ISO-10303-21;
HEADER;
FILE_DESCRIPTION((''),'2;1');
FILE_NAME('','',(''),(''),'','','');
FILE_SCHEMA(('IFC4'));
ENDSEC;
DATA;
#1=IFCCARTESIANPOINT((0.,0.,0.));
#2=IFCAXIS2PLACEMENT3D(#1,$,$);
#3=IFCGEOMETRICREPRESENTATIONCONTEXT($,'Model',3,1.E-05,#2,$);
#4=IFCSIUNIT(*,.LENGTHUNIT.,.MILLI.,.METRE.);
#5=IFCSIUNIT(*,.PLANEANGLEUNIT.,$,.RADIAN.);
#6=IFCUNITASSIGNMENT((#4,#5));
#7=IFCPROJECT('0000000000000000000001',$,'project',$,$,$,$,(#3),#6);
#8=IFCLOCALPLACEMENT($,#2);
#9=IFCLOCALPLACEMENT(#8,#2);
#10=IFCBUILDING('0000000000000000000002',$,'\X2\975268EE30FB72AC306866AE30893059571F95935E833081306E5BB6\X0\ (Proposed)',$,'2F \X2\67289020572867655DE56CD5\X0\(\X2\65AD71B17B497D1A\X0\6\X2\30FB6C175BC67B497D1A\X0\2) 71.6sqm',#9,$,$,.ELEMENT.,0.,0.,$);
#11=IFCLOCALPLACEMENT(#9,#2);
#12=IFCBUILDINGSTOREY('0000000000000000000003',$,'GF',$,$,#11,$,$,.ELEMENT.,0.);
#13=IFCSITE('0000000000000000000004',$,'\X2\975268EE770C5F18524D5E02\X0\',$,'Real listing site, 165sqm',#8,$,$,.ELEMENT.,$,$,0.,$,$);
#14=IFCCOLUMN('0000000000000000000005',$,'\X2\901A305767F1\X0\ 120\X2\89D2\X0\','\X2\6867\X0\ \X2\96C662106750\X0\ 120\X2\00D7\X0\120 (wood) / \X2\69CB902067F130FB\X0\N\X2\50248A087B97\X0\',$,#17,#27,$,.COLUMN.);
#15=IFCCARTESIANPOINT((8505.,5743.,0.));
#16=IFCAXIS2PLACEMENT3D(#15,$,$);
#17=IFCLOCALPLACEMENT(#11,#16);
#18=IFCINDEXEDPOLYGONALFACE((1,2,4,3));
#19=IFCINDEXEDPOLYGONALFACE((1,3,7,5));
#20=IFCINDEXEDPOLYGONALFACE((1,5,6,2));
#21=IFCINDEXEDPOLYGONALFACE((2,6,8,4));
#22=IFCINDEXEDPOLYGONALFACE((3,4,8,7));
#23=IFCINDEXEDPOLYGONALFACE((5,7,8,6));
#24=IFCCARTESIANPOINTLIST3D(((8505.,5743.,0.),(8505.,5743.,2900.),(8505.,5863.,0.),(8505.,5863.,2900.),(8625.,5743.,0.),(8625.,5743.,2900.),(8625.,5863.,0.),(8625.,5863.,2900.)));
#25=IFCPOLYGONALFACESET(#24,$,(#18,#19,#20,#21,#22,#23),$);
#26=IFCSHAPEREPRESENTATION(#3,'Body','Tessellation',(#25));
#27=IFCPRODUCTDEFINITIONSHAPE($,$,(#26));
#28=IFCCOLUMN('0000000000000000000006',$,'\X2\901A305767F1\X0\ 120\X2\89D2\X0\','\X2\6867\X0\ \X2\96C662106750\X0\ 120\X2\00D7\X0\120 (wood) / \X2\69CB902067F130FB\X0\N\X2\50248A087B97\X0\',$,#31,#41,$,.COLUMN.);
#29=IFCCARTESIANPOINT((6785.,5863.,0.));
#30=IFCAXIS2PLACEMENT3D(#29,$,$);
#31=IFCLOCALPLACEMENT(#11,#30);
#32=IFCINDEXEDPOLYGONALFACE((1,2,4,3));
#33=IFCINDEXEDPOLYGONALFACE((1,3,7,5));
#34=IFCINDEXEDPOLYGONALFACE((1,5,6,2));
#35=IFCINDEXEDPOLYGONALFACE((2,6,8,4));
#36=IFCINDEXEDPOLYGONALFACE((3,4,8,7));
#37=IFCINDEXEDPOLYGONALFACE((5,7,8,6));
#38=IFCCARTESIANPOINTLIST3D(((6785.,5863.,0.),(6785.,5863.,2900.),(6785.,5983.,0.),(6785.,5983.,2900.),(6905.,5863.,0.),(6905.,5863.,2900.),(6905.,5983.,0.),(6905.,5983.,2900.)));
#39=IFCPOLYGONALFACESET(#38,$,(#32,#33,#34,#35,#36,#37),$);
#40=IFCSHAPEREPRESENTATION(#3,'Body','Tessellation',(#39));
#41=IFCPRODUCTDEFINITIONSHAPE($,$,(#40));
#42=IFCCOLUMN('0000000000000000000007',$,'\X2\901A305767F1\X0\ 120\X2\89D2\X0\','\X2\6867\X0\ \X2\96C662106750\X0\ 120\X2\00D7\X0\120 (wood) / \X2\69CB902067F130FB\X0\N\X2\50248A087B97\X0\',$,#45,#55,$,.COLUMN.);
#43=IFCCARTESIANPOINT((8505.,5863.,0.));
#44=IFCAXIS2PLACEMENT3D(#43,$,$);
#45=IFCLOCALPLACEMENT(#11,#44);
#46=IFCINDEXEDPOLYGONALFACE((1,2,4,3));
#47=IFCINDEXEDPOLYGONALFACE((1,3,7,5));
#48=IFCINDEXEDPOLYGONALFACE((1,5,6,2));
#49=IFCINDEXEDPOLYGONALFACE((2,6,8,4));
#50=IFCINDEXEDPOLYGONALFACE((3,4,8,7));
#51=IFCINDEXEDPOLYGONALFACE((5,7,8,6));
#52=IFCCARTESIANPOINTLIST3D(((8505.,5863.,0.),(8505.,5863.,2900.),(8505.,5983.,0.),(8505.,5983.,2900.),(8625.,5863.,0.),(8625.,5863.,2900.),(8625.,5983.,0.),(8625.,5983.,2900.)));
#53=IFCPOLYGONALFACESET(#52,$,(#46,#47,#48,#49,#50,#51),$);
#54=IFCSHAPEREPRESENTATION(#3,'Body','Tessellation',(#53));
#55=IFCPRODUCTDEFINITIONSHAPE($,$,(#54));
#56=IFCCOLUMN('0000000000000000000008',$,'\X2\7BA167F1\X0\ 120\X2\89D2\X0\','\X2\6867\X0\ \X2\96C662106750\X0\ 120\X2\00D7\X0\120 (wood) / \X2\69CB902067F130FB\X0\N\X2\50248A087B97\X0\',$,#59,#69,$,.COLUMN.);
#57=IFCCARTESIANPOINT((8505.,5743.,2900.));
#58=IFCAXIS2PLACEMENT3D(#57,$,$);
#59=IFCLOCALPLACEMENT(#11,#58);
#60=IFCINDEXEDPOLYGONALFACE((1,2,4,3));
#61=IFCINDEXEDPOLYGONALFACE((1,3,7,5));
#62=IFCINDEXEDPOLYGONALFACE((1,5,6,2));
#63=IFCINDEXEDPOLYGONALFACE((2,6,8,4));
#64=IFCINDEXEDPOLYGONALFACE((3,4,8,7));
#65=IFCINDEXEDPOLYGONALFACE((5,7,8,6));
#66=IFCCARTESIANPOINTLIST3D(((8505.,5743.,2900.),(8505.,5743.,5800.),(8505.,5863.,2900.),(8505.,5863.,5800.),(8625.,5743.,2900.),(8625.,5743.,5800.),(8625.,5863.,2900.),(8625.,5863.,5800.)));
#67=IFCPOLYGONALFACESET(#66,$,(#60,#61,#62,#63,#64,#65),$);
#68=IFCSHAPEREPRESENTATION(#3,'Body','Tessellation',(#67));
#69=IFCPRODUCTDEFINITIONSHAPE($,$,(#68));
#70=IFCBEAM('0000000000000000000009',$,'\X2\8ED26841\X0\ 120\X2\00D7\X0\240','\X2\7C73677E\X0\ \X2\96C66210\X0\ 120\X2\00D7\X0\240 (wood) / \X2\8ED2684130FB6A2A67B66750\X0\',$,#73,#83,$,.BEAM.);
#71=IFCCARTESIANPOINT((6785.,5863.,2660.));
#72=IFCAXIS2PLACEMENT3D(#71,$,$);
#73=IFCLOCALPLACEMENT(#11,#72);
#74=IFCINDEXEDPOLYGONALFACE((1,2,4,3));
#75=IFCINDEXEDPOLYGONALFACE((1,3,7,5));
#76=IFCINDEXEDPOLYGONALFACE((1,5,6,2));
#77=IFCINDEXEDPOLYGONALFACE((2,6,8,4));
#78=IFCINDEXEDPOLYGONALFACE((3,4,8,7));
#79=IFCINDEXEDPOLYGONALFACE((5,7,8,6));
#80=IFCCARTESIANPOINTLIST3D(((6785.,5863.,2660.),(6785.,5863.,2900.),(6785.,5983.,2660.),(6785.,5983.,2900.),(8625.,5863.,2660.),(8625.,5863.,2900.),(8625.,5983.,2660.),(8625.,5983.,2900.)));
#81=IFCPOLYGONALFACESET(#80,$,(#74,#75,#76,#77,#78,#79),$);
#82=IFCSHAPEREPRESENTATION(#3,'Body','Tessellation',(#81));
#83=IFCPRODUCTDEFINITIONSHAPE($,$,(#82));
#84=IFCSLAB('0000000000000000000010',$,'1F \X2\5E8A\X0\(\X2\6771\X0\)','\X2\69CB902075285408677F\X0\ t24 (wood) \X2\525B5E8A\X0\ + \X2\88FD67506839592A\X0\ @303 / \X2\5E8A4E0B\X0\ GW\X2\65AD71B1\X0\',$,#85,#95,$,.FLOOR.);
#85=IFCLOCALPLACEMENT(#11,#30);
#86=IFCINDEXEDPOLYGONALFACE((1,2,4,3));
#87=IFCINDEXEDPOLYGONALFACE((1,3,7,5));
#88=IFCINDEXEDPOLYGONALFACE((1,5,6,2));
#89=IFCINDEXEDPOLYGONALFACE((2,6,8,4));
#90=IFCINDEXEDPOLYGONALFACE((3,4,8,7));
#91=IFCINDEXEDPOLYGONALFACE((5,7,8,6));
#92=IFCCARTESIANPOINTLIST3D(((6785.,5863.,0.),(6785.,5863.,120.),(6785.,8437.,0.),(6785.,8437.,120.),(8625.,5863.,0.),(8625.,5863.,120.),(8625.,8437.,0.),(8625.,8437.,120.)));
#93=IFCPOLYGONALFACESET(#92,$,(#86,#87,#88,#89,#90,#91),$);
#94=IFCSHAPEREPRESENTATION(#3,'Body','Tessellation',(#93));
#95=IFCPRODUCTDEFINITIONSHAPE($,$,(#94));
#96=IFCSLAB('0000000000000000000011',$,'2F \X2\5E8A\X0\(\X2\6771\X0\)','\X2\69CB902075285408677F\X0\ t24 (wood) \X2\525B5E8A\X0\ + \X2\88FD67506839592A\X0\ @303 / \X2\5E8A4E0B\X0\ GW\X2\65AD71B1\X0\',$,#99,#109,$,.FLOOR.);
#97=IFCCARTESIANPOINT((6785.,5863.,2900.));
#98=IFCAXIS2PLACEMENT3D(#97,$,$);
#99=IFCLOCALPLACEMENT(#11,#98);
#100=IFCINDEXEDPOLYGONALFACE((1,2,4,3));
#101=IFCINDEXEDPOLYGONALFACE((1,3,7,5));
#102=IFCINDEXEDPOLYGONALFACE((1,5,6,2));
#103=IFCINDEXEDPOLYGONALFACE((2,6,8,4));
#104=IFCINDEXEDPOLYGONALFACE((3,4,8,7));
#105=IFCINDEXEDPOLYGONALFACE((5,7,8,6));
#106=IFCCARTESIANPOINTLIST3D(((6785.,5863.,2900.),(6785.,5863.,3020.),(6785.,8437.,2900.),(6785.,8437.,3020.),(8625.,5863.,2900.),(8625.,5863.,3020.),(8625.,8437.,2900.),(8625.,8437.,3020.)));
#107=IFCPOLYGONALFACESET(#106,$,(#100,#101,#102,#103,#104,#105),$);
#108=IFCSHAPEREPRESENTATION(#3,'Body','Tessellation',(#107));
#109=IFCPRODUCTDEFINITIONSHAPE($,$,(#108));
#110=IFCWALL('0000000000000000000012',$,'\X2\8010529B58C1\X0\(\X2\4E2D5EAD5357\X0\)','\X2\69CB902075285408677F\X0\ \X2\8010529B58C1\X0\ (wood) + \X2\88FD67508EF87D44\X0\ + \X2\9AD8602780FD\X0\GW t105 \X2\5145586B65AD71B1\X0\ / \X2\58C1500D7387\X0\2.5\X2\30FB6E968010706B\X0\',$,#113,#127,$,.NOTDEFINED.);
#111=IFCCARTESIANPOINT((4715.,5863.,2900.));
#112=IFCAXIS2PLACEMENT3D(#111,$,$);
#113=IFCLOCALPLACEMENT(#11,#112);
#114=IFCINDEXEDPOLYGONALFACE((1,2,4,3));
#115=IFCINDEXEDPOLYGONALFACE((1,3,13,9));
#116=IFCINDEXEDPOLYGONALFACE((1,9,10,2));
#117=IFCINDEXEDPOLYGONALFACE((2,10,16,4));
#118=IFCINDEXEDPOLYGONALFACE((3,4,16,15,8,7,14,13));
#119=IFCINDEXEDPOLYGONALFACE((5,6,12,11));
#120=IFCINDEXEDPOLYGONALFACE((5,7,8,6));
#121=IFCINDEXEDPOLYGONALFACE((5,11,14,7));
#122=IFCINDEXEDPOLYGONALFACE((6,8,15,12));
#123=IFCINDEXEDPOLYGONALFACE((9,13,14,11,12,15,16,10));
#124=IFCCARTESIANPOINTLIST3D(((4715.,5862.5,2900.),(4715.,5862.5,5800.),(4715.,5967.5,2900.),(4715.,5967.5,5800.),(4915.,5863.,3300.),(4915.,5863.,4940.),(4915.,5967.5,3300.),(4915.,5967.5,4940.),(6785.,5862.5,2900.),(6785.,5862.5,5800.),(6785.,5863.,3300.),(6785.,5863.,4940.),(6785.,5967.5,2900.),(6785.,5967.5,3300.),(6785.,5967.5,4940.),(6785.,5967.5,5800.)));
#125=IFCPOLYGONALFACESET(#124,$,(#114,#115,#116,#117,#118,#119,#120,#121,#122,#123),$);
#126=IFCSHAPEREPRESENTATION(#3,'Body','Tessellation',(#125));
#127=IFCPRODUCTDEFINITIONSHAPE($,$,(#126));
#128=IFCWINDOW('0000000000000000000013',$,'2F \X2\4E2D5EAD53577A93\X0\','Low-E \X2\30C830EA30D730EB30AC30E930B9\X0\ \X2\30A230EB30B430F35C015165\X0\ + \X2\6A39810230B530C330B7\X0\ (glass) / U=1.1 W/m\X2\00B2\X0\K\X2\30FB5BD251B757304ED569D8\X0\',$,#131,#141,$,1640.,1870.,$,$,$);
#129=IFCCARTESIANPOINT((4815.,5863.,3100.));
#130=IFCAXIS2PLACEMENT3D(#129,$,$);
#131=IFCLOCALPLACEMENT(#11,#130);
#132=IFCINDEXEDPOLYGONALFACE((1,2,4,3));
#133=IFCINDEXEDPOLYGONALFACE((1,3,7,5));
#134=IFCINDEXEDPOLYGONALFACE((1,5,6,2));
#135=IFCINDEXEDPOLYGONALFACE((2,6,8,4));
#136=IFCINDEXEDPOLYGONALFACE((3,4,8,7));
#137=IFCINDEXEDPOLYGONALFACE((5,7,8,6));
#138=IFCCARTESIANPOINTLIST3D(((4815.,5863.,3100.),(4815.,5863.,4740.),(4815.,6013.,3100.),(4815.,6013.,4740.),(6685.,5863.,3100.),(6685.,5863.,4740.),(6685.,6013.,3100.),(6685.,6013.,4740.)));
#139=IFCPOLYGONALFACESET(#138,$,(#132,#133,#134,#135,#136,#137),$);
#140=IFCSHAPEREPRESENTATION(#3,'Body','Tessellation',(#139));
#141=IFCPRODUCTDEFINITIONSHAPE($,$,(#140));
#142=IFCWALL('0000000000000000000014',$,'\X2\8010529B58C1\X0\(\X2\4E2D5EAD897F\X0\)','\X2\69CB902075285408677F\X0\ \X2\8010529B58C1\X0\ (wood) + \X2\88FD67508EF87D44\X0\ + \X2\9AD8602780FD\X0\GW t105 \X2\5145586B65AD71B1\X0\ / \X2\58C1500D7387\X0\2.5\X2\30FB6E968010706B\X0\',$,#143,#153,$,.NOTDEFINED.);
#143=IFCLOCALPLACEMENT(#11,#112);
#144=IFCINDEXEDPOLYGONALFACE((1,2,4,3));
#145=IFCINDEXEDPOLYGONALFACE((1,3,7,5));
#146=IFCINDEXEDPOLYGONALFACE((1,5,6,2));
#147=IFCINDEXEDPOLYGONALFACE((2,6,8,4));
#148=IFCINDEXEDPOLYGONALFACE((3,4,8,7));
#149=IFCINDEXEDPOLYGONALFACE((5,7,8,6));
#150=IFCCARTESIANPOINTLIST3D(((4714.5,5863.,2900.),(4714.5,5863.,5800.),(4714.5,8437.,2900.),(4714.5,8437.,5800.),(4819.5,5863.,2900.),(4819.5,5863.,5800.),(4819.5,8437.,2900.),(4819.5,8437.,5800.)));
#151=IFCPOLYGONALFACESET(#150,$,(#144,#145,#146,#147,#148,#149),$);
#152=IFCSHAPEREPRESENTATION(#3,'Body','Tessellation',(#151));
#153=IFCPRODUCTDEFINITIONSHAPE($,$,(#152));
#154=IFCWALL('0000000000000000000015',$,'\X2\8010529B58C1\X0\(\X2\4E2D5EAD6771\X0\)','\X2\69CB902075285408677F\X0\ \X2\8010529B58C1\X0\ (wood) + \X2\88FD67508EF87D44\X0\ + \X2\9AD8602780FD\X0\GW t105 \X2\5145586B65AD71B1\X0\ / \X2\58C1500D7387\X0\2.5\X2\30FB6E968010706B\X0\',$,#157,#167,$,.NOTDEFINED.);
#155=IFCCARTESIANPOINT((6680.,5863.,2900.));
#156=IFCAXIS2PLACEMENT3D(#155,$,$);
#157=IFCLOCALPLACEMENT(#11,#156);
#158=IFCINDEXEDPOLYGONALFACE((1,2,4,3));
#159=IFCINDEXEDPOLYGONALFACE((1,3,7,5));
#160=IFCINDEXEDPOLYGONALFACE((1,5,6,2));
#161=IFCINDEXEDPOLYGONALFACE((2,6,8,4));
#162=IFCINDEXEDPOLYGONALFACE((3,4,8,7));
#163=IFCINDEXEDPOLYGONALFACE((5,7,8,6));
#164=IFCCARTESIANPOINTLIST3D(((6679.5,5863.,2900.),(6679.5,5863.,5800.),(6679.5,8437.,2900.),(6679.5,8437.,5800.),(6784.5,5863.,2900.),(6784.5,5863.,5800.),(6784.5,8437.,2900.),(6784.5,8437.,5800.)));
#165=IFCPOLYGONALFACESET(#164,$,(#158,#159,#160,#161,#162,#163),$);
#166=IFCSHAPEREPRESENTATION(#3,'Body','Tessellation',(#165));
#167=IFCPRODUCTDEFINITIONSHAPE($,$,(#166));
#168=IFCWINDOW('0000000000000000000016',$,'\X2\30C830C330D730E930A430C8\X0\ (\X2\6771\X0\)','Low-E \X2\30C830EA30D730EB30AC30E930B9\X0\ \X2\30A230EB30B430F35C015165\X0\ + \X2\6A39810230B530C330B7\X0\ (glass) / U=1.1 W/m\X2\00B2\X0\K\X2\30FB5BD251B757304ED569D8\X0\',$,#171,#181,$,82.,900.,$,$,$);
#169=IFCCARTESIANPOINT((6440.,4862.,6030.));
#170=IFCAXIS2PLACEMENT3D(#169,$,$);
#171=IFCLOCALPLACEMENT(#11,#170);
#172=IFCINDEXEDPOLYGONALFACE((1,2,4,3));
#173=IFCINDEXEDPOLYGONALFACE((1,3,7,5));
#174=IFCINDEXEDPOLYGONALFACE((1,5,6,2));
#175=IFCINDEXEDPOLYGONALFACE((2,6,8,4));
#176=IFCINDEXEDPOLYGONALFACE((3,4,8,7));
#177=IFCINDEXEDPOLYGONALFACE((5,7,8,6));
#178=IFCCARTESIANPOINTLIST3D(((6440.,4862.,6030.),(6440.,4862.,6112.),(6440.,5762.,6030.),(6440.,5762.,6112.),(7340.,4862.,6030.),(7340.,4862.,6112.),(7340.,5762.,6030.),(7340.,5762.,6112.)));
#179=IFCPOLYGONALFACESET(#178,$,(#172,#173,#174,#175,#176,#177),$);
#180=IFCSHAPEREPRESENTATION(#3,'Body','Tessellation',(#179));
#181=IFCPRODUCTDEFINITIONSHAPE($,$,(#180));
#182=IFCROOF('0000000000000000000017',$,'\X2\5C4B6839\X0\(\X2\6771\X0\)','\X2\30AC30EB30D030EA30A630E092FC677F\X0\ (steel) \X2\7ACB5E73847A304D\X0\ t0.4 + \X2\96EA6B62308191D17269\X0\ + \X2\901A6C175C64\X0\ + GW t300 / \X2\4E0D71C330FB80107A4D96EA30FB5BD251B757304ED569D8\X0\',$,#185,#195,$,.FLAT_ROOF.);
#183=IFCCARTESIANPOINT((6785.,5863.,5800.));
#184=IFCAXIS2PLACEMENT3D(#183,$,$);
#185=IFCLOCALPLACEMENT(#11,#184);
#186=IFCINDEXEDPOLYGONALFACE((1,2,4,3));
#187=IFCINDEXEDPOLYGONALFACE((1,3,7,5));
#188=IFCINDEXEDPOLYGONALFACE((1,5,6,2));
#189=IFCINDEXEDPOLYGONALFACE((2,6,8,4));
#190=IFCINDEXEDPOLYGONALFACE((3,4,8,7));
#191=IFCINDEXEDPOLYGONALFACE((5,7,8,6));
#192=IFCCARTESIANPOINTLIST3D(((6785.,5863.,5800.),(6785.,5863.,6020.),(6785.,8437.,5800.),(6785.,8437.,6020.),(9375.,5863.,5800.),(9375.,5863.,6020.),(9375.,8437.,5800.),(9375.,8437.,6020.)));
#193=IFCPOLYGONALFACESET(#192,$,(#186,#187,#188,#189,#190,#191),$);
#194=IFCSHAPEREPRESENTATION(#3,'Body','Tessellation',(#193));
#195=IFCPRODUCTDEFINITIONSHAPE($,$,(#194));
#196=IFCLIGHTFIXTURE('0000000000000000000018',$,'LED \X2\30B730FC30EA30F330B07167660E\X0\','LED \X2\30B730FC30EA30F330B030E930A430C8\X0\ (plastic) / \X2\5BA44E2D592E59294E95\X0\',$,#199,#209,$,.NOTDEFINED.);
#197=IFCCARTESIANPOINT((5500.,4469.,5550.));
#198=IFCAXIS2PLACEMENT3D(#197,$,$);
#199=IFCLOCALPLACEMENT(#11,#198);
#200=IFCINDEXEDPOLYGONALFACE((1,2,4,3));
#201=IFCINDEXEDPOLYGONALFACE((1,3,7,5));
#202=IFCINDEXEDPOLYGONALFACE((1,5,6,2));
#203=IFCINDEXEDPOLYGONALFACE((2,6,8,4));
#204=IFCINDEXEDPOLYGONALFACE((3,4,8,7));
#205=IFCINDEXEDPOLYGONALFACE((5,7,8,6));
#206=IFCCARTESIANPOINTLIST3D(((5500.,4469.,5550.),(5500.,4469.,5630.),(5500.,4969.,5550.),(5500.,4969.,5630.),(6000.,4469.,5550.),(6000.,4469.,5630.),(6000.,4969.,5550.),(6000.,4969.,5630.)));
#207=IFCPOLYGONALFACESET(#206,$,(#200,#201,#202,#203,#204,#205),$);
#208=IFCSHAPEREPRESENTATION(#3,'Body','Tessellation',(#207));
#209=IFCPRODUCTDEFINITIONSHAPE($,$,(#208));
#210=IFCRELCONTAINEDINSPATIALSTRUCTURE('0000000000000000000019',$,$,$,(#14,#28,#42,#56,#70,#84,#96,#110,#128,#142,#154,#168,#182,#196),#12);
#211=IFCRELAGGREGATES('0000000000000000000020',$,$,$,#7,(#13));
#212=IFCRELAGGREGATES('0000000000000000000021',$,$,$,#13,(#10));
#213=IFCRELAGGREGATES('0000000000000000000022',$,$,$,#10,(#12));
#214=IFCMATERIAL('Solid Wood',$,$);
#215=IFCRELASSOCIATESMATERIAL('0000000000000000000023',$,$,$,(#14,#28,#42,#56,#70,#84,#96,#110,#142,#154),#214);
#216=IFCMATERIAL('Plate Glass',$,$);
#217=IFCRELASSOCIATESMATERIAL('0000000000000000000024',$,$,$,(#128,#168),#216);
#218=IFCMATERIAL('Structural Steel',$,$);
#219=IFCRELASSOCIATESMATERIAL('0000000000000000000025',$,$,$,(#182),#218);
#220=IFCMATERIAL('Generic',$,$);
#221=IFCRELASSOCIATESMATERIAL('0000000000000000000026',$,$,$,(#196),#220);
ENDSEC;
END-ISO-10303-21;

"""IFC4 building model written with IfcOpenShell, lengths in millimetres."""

from ifc_helpers import new_model, si_unit, frame, frame_2d, origin, place, context, project, spatial, rectangle, extrude, material, element, fill, save


model = new_model("IFC4")

# Units and contexts
model_context = context("Model", 3, precision=1e-05, world=origin())
ifc_project = project(units=[si_unit("LENGTHUNIT", "METRE", prefix="MILLI"), si_unit("PLANEANGLEUNIT", "RADIAN")], contexts=[model_context])

# Site, building, storey
site_placement = place(None, origin())
site = spatial("IfcSite", under=ifc_project, at=site_placement, Name="青森県弘前市", ObjectType="Real listing site, 165sqm", CompositionType="ELEMENT", RefElevation=0.0)
building_placement = place(site_placement, origin())
building = spatial("IfcBuilding", under=site, at=building_placement, Name="青森・犬と暮らす土間広めの家 (Proposed)", ObjectType="2F 木造在来工法(断熱等級6・気密等級2) 71.6sqm", CompositionType="ELEMENT", ElevationOfRefHeight=0.0, ElevationOfTerrain=0.0)
storey_placement = place(building_placement, origin())
storey = spatial("IfcBuildingStorey", under=building, at=storey_placement, Name="GF", CompositionType="ELEMENT", Elevation=0.0)

# Columns
ifc_material_1 = material(Name="Solid Wood")
column_1_placement = place(storey_placement, frame((8505.0, 5743.0, 0.0)))
element("IfcColumn", 1, at=column_1_placement, inside=storey, material=ifc_material_1, Name="通し柱 120角", Description="桧 集成材 120×120 (wood) / 構造柱・N値計算", PredefinedType="COLUMN", context=model_context, shape_type="SweptSolid", body=[
    extrude(rectangle(XDim=120.0, YDim=120.0, at=frame_2d((60.0, 60.0))), frame((8505.0, 5743.0, 0.0)), (0.0, 0.0, 1.0), 2900.0),
])
column_2_placement = place(storey_placement, frame((6785.0, 5863.0, 0.0)))
element("IfcColumn", 2, at=column_2_placement, inside=storey, material=ifc_material_1, Name="通し柱 120角", Description="桧 集成材 120×120 (wood) / 構造柱・N値計算", PredefinedType="COLUMN", context=model_context, shape_type="SweptSolid", body=[
    extrude(rectangle(XDim=120.0, YDim=120.0, at=frame_2d((60.0, 60.0))), frame((6785.0, 5863.0, 0.0)), (0.0, 0.0, 1.0), 2900.0),
])
column_3_placement = place(storey_placement, frame((8505.0, 5863.0, 0.0)))
element("IfcColumn", 3, at=column_3_placement, inside=storey, material=ifc_material_1, Name="通し柱 120角", Description="桧 集成材 120×120 (wood) / 構造柱・N値計算", PredefinedType="COLUMN", context=model_context, shape_type="SweptSolid", body=[
    extrude(rectangle(XDim=120.0, YDim=120.0, at=frame_2d((60.0, 60.0))), frame((8505.0, 5863.0, 0.0)), (0.0, 0.0, 1.0), 2900.0),
])
column_4_placement = place(storey_placement, frame((8505.0, 5743.0, 2900.0)))
element("IfcColumn", 4, at=column_4_placement, inside=storey, material=ifc_material_1, Name="管柱 120角", Description="桧 集成材 120×120 (wood) / 構造柱・N値計算", PredefinedType="COLUMN", context=model_context, shape_type="SweptSolid", body=[
    extrude(rectangle(XDim=120.0, YDim=120.0, at=frame_2d((60.0, 60.0))), frame((8505.0, 5743.0, 2900.0)), (0.0, 0.0, 1.0), 2900.0),
])

# Beam
beam_1_placement = place(storey_placement, frame((6785.0, 5863.0, 2660.0)))
element("IfcBeam", 5, at=beam_1_placement, inside=storey, material=ifc_material_1, Name="軒桁 120×240", Description="米松 集成 120×240 (wood) / 軒桁・横架材", PredefinedType="BEAM", context=model_context, shape_type="SweptSolid", body=[
    extrude(rectangle(XDim=1840.0, YDim=120.0, at=frame_2d((920.0, 60.0))), frame((6785.0, 5863.0, 2660.0)), (0.0, 0.0, 1.0), 240.0),
])

# Slabs
slab_1_placement = place(storey_placement, frame((6785.0, 5863.0, 0.0)))
element("IfcSlab", 6, at=slab_1_placement, inside=storey, material=ifc_material_1, Name="1F 床(東)", Description="構造用合板 t24 (wood) 剛床 + 製材根太 @303 / 床下 GW断熱", PredefinedType="FLOOR", context=model_context, shape_type="SweptSolid", body=[
    extrude(rectangle(XDim=1840.0, YDim=2574.0, at=frame_2d((920.0, 1287.0))), frame((6785.0, 5863.0, 0.0)), (0.0, 0.0, 1.0), 120.0),
])
slab_2_placement = place(storey_placement, frame((6785.0, 5863.0, 2900.0)))
element("IfcSlab", 7, at=slab_2_placement, inside=storey, material=ifc_material_1, Name="2F 床(東)", Description="構造用合板 t24 (wood) 剛床 + 製材根太 @303 / 床下 GW断熱", PredefinedType="FLOOR", context=model_context, shape_type="SweptSolid", body=[
    extrude(rectangle(XDim=1840.0, YDim=2574.0, at=frame_2d((920.0, 1287.0))), frame((6785.0, 5863.0, 2900.0)), (0.0, 0.0, 1.0), 120.0),
])

# Wall, opening, window
wall_1_placement = place(storey_placement, frame((4715.0, 5863.0, 2900.0)))
wall_1 = element("IfcWall", 8, at=wall_1_placement, inside=storey, material=ifc_material_1, Name="耐力壁(中庭南)", Description="構造用合板 耐力壁 (wood) + 製材軸組 + 高性能GW t105 充填断熱 / 壁倍率2.5・準耐火", PredefinedType="NOTDEFINED", context=model_context, shape_type="SweptSolid", body=[
    extrude(rectangle(XDim=2070.0, YDim=105.0, at=frame_2d((1035.0, 52.0))), frame((4715.0, 5863.0, 2900.0)), (0.0, 0.0, 1.0), 2900.0),
])
opening_placement = place(storey_placement, frame((4815.0, 5863.0, 3100.0)))
opening = element("IfcOpeningElement", 9, at=opening_placement, cuts=wall_1, PredefinedType="NOTDEFINED", context=model_context, shape_type="SweptSolid", body=[
    extrude(rectangle(XDim=1870.0, YDim=150.0, at=frame_2d((935.0, 75.0))), frame((4815.0, 5863.0, 3100.0)), (0.0, 0.0, 1.0), 1640.0),
])
ifc_material_2 = material(Name="Plate Glass")
window_1_placement = place(storey_placement, frame((4815.0, 5863.0, 3100.0)))
window_1 = element("IfcWindow", 10, at=window_1_placement, inside=storey, material=ifc_material_2, Name="2F 中庭南窓", Description="Low-E トリプルガラス アルゴン封入 + 樹脂サッシ (glass) / U=1.1 W/m²K・寒冷地仕様", OverallHeight=1640.0, OverallWidth=1870.0, context=model_context, shape_type="SweptSolid", body=[
    extrude(rectangle(XDim=1870.0, YDim=150.0, at=frame_2d((935.0, 75.0))), frame((4815.0, 5863.0, 3100.0)), (0.0, 0.0, 1.0), 1640.0),
])
fill(opening, window_1)

# Walls
wall_2_placement = place(storey_placement, frame((4715.0, 5863.0, 2900.0)))
element("IfcWall", 11, at=wall_2_placement, inside=storey, material=ifc_material_1, Name="耐力壁(中庭西)", Description="構造用合板 耐力壁 (wood) + 製材軸組 + 高性能GW t105 充填断熱 / 壁倍率2.5・準耐火", PredefinedType="NOTDEFINED", context=model_context, shape_type="SweptSolid", body=[
    extrude(rectangle(XDim=105.0, YDim=2574.0, at=frame_2d((52.0, 1287.0))), frame((4715.0, 5863.0, 2900.0)), (0.0, 0.0, 1.0), 2900.0),
])
wall_3_placement = place(storey_placement, frame((6680.0, 5863.0, 2900.0)))
element("IfcWall", 12, at=wall_3_placement, inside=storey, material=ifc_material_1, Name="耐力壁(中庭東)", Description="構造用合板 耐力壁 (wood) + 製材軸組 + 高性能GW t105 充填断熱 / 壁倍率2.5・準耐火", PredefinedType="NOTDEFINED", context=model_context, shape_type="SweptSolid", body=[
    extrude(rectangle(XDim=105.0, YDim=2574.0, at=frame_2d((52.0, 1287.0))), frame((6680.0, 5863.0, 2900.0)), (0.0, 0.0, 1.0), 2900.0),
])

# Window
window_2_placement = place(storey_placement, frame((6440.0, 4862.0, 6030.0)))
element("IfcWindow", 13, at=window_2_placement, inside=storey, material=ifc_material_2, Name="トップライト (東)", Description="Low-E トリプルガラス アルゴン封入 + 樹脂サッシ (glass) / U=1.1 W/m²K・寒冷地仕様", OverallHeight=82.0, OverallWidth=900.0, context=model_context, shape_type="SweptSolid", body=[
    extrude(rectangle(XDim=900.0, YDim=900.0, at=frame_2d((450.0, 450.0))), frame((6440.0, 4862.0, 6030.0)), (0.0, 0.0, 1.0), 82.0),
])

# Roof
ifc_material_3 = material(Name="Structural Steel")
for number, where, name in (
    (14, (6785.0, 5863.0, 5800.0), "屋根(東)"),
):
    element("IfcRoof", number, at=place(storey_placement, frame(where)), inside=storey, material=ifc_material_3, Name=name, Description="ガルバリウム鋼板 (steel) 立平葺き t0.4 + 雪止め金物 + 通気層 + GW t300 / 不燃・耐積雪・寒冷地仕様", PredefinedType="FLAT_ROOF", context=model_context, shape_type="SweptSolid", body=[
        extrude(rectangle(XDim=2590.0, YDim=2574.0, at=frame_2d((1295.0, 1287.0))), frame((6785.0, 5863.0, 5800.0)), (0.0, 0.0, 1.0), 220.0),
    ])

# Light fixture
ifc_material_4 = material(Name="Generic")
light_fixture_placement = place(storey_placement, frame((5500.0, 4469.0, 5550.0)))
element("IfcLightFixture", 15, at=light_fixture_placement, inside=storey, material=ifc_material_4, Name="LED シーリング照明", Description="LED シーリングライト (plastic) / 室中央天井", PredefinedType="NOTDEFINED", context=model_context, shape_type="SweptSolid", body=[
    extrude(rectangle(XDim=500.0, YDim=500.0, at=frame_2d((250.0, 250.0))), frame((5500.0, 4469.0, 5550.0)), (0.0, 0.0, 1.0), 80.0),
])

save(model, "model.ifc")
